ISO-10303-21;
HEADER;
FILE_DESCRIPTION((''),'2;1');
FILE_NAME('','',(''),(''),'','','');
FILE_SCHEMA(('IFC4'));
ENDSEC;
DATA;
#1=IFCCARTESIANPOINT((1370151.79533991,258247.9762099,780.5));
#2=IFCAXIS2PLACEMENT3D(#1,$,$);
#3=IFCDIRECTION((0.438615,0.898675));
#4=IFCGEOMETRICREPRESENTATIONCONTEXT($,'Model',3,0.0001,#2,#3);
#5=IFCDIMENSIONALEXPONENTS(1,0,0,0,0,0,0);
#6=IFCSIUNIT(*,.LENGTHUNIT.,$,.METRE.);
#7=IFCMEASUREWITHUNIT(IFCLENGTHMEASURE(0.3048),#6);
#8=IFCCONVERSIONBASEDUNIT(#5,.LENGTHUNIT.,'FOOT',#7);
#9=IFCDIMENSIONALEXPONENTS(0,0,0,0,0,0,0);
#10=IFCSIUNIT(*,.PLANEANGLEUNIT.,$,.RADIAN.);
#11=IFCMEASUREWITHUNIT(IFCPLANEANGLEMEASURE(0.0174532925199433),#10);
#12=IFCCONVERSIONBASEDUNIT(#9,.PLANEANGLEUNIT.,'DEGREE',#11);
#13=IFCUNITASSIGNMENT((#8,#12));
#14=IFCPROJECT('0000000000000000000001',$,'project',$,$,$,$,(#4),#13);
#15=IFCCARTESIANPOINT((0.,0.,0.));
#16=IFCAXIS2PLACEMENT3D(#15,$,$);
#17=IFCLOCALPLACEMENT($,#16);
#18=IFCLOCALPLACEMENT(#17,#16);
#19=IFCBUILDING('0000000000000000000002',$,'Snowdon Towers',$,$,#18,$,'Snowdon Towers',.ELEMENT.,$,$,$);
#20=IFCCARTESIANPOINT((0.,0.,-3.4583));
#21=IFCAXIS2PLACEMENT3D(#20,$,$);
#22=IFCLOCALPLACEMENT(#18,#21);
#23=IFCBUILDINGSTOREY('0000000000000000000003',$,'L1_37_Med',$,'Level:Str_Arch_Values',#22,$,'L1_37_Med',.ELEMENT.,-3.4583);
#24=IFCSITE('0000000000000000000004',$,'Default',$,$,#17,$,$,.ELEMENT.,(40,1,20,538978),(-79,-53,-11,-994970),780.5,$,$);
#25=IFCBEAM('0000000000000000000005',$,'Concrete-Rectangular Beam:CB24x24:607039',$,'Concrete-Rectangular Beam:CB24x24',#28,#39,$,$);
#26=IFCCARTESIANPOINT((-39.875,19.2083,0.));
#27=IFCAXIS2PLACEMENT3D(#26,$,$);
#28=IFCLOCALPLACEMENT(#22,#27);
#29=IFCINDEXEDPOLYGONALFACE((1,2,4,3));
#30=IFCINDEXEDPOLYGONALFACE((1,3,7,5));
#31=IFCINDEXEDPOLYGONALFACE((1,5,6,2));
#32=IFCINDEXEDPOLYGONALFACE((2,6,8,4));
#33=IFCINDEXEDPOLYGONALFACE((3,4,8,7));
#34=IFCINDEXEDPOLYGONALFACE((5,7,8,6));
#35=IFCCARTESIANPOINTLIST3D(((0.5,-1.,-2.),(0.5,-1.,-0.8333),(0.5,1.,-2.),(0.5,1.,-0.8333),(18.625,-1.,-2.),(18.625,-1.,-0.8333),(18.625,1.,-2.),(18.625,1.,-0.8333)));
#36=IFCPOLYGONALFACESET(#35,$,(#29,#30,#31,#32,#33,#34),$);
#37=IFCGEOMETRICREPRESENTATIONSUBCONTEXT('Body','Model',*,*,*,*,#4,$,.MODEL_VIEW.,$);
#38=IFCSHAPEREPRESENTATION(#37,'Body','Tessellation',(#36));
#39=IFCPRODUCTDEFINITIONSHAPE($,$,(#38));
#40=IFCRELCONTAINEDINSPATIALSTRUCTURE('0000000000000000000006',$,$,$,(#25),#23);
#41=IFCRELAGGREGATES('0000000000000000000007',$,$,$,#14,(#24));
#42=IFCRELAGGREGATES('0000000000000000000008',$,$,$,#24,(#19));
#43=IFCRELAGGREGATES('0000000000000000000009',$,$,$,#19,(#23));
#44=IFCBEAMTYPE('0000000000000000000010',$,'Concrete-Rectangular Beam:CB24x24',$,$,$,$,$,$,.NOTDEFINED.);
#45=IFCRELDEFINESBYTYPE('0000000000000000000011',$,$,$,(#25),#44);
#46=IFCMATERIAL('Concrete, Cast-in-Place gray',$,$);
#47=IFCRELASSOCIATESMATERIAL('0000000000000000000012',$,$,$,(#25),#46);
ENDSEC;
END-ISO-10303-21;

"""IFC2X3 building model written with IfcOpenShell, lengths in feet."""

from ifc_helpers import new_model, entity, si_unit, converted_unit, direction, frame, frame_2d, origin, place, context, subcontext, project, spatial, rectangle, extrude, material, type_object, element, save


model = new_model("IFC2X3")

# Units and contexts
model_context = context("Model", 3, precision=0.0001, world=frame((1370151.79533991, 258247.9762099, 780.5)), true_north=direction((0.438615, 0.898675)))
body_context = subcontext(model_context, "Body", "Model", "MODEL_VIEW")
ifc_project = project(units=[converted_unit("LENGTHUNIT", "FOOT", entity("IfcLengthMeasure", 0.3048), si_unit("LENGTHUNIT", "METRE"), dimensions=[1, 0, 0, 0, 0, 0, 0]), converted_unit("PLANEANGLEUNIT", "DEGREE", entity("IfcPlaneAngleMeasure", 0.0174532925199433), si_unit("PLANEANGLEUNIT", "RADIAN"), dimensions=[0, 0, 0, 0, 0, 0, 0])], contexts=[model_context])

# Site, building, storey
site_placement = place(None, origin())
site = spatial("IfcSite", under=ifc_project, at=site_placement, Name="Default", CompositionType="ELEMENT", RefLatitude=(40, 1, 20, 538978), RefLongitude=(-79, -53, -11, -994970), RefElevation=780.5)
building_placement = place(site_placement, origin())
building = spatial("IfcBuilding", under=site, at=building_placement, Name="Snowdon Towers", LongName="Snowdon Towers", CompositionType="ELEMENT")
storey_placement = place(building_placement, frame((0.0, 0.0, -3.4583)))
storey = spatial("IfcBuildingStorey", under=building, at=storey_placement, Name="L1_37_Med", ObjectType="Level:Str_Arch_Values", LongName="L1_37_Med", CompositionType="ELEMENT", Elevation=-3.4583)

# Beam
ifc_material_1 = material(Name="Concrete, Cast-in-Place gray")
beam_type_1 = type_object("IfcBeamType", Name="Concrete-Rectangular Beam:CB24x24", PredefinedType="NOTDEFINED")
beam_1_placement = place(storey_placement, frame((-39.875, 19.2083, 0.0)))
element("IfcBeam", 1, at=beam_1_placement, inside=storey, type_object=beam_type_1, material=ifc_material_1, Name="Concrete-Rectangular Beam:CB24x24:607039", ObjectType="Concrete-Rectangular Beam:CB24x24", context=body_context, shape_type="SweptSolid", body=[
    extrude(rectangle(XDim=1.1667, YDim=2.0, at=frame_2d((0.0, 0.0), x_axis=(1.0, 0.0))), frame((0.5, 0.0, -1.4167), z_axis=(1.0, 0.0, 0.0), x_axis=(0.0, 0.0, -1.0)), (0.0, 0.0, 1.0), 18.125),
])

save(model, "model.ifc")
